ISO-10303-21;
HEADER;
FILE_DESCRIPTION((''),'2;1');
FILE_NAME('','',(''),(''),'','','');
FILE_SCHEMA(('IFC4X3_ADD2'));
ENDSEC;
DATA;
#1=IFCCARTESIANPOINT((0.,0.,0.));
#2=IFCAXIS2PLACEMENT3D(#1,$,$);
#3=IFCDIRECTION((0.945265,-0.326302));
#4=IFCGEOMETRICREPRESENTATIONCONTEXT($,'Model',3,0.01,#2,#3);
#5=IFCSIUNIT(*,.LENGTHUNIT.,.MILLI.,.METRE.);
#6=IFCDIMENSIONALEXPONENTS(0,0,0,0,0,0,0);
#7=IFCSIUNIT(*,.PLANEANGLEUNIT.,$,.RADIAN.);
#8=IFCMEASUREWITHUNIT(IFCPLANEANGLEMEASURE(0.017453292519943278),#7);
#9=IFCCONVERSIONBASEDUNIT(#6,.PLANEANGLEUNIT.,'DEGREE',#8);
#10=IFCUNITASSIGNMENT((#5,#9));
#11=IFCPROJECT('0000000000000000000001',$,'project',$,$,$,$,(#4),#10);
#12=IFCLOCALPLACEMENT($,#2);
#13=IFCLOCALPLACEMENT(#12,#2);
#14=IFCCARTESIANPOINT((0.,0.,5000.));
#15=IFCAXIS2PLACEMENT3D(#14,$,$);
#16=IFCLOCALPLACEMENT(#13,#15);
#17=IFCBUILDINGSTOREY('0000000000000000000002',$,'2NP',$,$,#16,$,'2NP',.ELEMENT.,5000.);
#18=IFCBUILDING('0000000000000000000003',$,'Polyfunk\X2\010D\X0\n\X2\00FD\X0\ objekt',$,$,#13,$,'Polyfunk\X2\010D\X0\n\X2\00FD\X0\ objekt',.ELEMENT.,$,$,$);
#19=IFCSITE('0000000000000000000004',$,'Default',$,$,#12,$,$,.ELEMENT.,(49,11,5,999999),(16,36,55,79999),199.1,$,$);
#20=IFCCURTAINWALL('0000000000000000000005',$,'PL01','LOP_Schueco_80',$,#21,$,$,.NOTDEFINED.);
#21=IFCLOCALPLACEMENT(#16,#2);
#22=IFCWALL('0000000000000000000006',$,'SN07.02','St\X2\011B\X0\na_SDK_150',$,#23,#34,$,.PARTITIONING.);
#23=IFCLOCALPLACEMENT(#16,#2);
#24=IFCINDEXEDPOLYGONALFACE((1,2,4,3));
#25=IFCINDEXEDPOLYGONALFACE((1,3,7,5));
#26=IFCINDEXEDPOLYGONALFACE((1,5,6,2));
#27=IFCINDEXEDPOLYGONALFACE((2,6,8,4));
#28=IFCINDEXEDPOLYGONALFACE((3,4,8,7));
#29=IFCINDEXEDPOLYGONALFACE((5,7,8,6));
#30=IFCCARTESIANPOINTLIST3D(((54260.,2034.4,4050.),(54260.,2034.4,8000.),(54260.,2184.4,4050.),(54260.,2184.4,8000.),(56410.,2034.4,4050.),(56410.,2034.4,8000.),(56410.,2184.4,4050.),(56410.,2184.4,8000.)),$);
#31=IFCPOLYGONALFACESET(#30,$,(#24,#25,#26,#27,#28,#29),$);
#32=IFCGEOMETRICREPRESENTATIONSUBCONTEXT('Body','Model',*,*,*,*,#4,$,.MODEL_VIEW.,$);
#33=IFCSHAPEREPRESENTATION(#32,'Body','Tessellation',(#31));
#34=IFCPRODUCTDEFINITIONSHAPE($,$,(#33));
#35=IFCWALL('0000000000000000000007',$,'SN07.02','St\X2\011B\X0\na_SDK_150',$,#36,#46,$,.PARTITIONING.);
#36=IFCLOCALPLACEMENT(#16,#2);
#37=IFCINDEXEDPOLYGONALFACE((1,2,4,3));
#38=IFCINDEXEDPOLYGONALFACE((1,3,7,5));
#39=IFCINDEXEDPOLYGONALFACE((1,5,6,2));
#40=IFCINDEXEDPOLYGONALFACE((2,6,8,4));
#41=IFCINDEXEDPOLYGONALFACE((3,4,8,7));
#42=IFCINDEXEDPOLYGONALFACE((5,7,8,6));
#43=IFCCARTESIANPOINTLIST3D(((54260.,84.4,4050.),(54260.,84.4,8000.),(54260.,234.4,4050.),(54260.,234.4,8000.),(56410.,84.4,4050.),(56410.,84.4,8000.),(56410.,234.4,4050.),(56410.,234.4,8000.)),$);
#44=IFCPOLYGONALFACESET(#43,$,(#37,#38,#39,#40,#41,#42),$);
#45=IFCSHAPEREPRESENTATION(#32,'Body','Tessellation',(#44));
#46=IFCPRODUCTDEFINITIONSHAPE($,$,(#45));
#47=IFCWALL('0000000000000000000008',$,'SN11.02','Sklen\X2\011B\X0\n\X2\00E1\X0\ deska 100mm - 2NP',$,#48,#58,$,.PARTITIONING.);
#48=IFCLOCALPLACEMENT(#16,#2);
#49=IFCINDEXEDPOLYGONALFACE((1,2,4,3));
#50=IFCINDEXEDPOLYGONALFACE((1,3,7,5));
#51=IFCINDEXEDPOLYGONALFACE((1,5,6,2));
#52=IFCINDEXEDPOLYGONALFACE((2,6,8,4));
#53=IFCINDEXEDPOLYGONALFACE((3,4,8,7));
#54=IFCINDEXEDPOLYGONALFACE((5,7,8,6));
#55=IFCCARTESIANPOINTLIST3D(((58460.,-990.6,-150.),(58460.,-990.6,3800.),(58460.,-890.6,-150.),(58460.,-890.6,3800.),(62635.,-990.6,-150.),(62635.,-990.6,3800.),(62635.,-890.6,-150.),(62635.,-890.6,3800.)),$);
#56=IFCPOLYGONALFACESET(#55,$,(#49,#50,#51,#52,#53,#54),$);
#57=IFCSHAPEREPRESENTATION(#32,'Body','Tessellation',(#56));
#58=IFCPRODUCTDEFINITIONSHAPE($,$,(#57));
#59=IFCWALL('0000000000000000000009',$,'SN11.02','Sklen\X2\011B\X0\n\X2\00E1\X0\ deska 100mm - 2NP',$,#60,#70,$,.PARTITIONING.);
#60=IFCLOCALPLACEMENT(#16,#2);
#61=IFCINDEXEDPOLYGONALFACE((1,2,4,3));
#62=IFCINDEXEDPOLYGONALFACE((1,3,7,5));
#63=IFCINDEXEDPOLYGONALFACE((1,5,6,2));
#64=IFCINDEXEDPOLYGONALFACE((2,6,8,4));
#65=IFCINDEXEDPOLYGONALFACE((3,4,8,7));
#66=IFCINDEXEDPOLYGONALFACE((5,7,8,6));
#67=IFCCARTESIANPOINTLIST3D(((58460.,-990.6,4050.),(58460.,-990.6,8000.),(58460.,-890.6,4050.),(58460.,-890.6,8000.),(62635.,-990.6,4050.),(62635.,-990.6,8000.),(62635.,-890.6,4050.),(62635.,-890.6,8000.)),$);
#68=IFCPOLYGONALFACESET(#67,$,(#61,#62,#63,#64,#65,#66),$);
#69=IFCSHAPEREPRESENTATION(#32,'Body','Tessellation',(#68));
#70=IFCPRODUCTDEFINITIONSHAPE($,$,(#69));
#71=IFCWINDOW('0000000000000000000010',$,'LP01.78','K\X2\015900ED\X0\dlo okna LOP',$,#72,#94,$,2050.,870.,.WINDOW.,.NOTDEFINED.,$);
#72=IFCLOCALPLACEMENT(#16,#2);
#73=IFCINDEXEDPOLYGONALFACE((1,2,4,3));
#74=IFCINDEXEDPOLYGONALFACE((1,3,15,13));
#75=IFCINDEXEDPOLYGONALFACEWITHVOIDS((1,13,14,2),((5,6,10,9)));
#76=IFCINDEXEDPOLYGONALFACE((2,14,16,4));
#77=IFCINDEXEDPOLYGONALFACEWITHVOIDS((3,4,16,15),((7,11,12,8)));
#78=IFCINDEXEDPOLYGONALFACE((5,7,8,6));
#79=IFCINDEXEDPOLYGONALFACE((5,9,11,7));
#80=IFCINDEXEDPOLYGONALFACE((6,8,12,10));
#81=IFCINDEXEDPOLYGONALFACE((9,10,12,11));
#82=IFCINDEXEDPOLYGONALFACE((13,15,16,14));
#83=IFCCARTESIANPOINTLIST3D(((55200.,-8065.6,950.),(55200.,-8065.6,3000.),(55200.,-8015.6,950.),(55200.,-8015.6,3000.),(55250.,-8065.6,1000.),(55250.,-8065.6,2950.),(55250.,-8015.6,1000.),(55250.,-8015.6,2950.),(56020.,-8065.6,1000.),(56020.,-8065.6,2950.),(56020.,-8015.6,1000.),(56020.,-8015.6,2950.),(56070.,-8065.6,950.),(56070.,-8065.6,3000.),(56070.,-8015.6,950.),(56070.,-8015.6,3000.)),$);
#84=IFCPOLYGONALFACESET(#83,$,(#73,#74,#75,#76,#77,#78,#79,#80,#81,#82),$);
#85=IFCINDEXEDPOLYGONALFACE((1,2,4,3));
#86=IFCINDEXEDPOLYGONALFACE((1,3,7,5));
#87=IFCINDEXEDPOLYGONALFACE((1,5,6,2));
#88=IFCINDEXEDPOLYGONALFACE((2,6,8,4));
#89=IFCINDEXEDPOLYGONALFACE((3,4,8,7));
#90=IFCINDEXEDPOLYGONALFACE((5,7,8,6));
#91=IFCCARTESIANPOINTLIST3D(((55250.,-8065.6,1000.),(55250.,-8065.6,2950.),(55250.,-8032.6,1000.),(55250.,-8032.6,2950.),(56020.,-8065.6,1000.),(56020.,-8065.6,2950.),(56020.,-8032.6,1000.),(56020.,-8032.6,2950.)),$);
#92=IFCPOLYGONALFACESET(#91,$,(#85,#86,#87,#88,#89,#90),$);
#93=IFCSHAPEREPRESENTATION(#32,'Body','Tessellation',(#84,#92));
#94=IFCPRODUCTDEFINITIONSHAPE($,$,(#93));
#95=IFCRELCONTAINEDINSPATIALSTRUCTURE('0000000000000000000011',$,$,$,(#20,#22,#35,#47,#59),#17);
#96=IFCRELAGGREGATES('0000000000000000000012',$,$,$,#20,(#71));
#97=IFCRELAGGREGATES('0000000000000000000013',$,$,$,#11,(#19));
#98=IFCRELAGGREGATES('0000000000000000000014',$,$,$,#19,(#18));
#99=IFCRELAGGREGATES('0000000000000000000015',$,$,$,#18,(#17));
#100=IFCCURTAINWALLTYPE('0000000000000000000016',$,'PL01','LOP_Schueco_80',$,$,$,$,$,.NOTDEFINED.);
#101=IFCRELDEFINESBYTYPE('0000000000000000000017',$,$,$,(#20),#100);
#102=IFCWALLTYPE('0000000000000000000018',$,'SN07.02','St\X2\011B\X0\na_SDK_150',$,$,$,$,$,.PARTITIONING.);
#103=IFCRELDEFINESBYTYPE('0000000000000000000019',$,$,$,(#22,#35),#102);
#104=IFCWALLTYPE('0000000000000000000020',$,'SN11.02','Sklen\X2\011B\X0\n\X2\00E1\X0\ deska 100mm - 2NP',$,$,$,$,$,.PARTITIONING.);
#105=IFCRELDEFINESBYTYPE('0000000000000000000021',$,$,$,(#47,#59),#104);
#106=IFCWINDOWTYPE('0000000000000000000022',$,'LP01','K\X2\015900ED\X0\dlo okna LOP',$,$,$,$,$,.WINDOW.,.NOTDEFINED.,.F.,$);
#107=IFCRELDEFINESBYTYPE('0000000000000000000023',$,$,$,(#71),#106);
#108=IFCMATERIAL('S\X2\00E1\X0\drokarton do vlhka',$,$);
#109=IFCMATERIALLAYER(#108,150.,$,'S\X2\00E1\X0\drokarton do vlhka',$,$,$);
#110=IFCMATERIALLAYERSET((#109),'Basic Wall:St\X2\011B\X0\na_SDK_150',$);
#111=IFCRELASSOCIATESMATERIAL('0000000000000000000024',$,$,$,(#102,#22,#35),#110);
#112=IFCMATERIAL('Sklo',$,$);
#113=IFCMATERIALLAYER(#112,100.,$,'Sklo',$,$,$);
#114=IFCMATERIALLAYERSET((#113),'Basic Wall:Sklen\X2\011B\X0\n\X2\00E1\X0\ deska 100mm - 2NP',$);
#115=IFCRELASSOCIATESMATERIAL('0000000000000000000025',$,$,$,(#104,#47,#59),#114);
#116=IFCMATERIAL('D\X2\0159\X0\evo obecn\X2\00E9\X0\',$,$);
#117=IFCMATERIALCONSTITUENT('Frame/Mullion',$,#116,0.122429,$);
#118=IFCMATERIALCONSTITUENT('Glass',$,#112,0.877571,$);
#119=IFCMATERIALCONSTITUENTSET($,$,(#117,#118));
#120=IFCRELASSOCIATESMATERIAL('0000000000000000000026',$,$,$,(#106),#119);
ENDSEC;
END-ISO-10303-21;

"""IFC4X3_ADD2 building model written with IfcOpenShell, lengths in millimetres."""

from ifc_helpers import new_model, entity, si_unit, converted_unit, direction, frame, frame_2d, origin, place, context, subcontext, project, spatial, polyline, rectangle, outline, extrude, clip, bounded_halfspace, source, transform, mapped, material, layer, layer_set, constituent, constituent_set, type_object, type_shapes, element, aggregate, save


model = new_model("IFC4X3_ADD2")

# Units and contexts
model_context = context("Model", 3, precision=0.01, world=origin(), true_north=direction((0.945265, -0.326302)))
body_context = subcontext(model_context, "Body", "Model", "MODEL_VIEW")
ifc_project = project(units=[si_unit("LENGTHUNIT", "METRE", prefix="MILLI"), converted_unit("PLANEANGLEUNIT", "DEGREE", entity("IfcPlaneAngleMeasure", 0.017453292519943278), si_unit("PLANEANGLEUNIT", "RADIAN"), dimensions=[0, 0, 0, 0, 0, 0, 0])], contexts=[model_context])

# Site, building, storey
site_placement = place(None, origin())
site = spatial("IfcSite", under=ifc_project, at=site_placement, Name="Default", CompositionType="ELEMENT", RefLatitude=(49, 11, 5, 999999), RefLongitude=(16, 36, 55, 79999), RefElevation=199.1)
building_placement = place(site_placement, origin())
building = spatial("IfcBuilding", under=site, at=building_placement, Name="Polyfunkčný objekt", LongName="Polyfunkčný objekt", CompositionType="ELEMENT")
storey_placement = place(building_placement, frame((0.0, 0.0, 5000.0)))
storey = spatial("IfcBuildingStorey", under=building, at=storey_placement, Name="2NP", LongName="2NP", CompositionType="ELEMENT", Elevation=5000.0)

# Curtain wall
curtain_wall_type = type_object("IfcCurtainWallType", Name="PL01", Description="LOP_Schueco_80", PredefinedType="NOTDEFINED")
curtain_wall_placement = place(storey_placement, frame((0.0, 0.0, -5000.0)))
curtain_wall = element("IfcCurtainWall", 1, at=curtain_wall_placement, inside=storey, type_object=curtain_wall_type, Name="PL01", Description="LOP_Schueco_80", PredefinedType="NOTDEFINED")
ifc_material_1 = material(Name="Sklo")

# Walls
ifc_material_2 = material(Name="Sádrokarton do vlhka")
ifc_layer_1 = layer(ifc_material_2, 150.0, Name="Sádrokarton do vlhka")
ifc_layer_set_1 = layer_set([ifc_layer_1], Name="Basic Wall:Stěna_SDK_150")
wall_type_1 = type_object("IfcWallType", Name="SN07.02", Description="Stěna_SDK_150", PredefinedType="PARTITIONING", material=ifc_layer_set_1)
wall_1_placement = place(storey_placement, frame((56410.0, 2109.4, 4050.0), z_axis=(0.0, 0.0, 1.0), x_axis=(-1.0, 0.0, 0.0)))
element("IfcWall", 2, at=wall_1_placement, inside=storey, type_object=wall_type_1, material=ifc_layer_set_1, Name="SN07.02", Description="Stěna_SDK_150", PredefinedType="PARTITIONING", context=body_context, shape_type="Clipping", body=[
    clip(clip(extrude(rectangle(XDim=2150.0, YDim=150.0, at=frame_2d((1075.0, 0.0), x_axis=(-1.0, 0.0))), origin(), (0.0, 0.0, 1.0), 3950.0), bounded_halfspace(frame((2150.0, -75.0, 0.0)), True, frame((2150.0, -75.0, 0.0)), polyline([(0.0, 0.0), (0.0, 150.0), (-2150.0, 150.0), (-2150.0, 0.0), (0.0, 0.0)]))), bounded_halfspace(frame((0.0, -75.0, 3950.0), z_axis=(0.0, 0.0, -1.0), x_axis=(-1.0, 0.0, 0.0)), True, frame((0.0, -75.0, 3950.0)), polyline([(0.0, 0.0), (2150.0, 0.0), (2150.0, 150.0), (0.0, 150.0), (0.0, 0.0)]))),
])
wall_2_placement = place(storey_placement, frame((56410.0, 159.4, 4050.0), z_axis=(0.0, 0.0, 1.0), x_axis=(-1.0, 0.0, 0.0)))
element("IfcWall", 3, at=wall_2_placement, inside=storey, type_object=wall_type_1, material=ifc_layer_set_1, Name="SN07.02", Description="Stěna_SDK_150", PredefinedType="PARTITIONING", context=body_context, shape_type="Clipping", body=[
    clip(clip(extrude(rectangle(XDim=2150.0, YDim=150.0, at=frame_2d((1075.0, 0.0), x_axis=(-1.0, 0.0))), origin(), (0.0, 0.0, 1.0), 3950.0), bounded_halfspace(frame((2150.0, -75.0, 0.0)), True, frame((2150.0, -75.0, 0.0)), polyline([(0.0, 0.0), (0.0, 150.0), (-2150.0, 150.0), (-2150.0, 0.0), (0.0, 0.0)]))), bounded_halfspace(frame((0.0, -75.0, 3950.0), z_axis=(0.0, 0.0, -1.0), x_axis=(-1.0, 0.0, 0.0)), True, frame((0.0, -75.0, 3950.0)), polyline([(0.0, 0.0), (2150.0, 0.0), (2150.0, 150.0), (0.0, 150.0), (0.0, 0.0)]))),
])
ifc_layer_2 = layer(ifc_material_1, 100.0, Name="Sklo")
ifc_layer_set_2 = layer_set([ifc_layer_2], Name="Basic Wall:Skleněná deska 100mm - 2NP")
wall_type_2 = type_object("IfcWallType", Name="SN11.02", Description="Skleněná deska 100mm - 2NP", PredefinedType="PARTITIONING", material=ifc_layer_set_2)
wall_3_placement = place(storey_placement, frame((58460.0, -940.6, -150.0)))
element("IfcWall", 4, at=wall_3_placement, inside=storey, type_object=wall_type_2, material=ifc_layer_set_2, Name="SN11.02", Description="Skleněná deska 100mm - 2NP", PredefinedType="PARTITIONING", context=body_context, shape_type="Clipping", body=[
    clip(clip(extrude(rectangle(XDim=4175.0, YDim=100.0, at=frame_2d((2087.5, 0.0), x_axis=(-1.0, 0.0))), origin(), (0.0, 0.0, 1.0), 3950.0), bounded_halfspace(frame((4175.0, -50.0, 0.0), z_axis=(0.0, 0.0, 1.0), x_axis=(-1.0, 0.0, 0.0)), True, frame((4175.0, -50.0, 0.0)), polyline([(0.0, 0.0), (0.0, 100.0), (-4075.0, 100.0), (-4175.0, 100.0), (-4175.0, 0.0), (0.0, 0.0)]))), bounded_halfspace(frame((0.0, -50.0, 3950.0), z_axis=(0.0, 0.0, -1.0), x_axis=(1.0, 0.0, 0.0)), True, frame((0.0, -50.0, 3950.0)), polyline([(0.0, 0.0), (4175.0, 0.0), (4175.0, 100.0), (100.0, 100.0), (0.0, 100.0), (0.0, 0.0)]))),
])
wall_4_placement = place(storey_placement, frame((58460.0, -940.6, 4050.0)))
element("IfcWall", 5, at=wall_4_placement, inside=storey, type_object=wall_type_2, material=ifc_layer_set_2, Name="SN11.02", Description="Skleněná deska 100mm - 2NP", PredefinedType="PARTITIONING", context=body_context, shape_type="Clipping", body=[
    clip(clip(extrude(rectangle(XDim=4175.0, YDim=100.0, at=frame_2d((2087.5, 0.0), x_axis=(-1.0, 0.0))), origin(), (0.0, 0.0, 1.0), 3950.0), bounded_halfspace(frame((4175.0, -50.0, 0.0), z_axis=(0.0, 0.0, 1.0), x_axis=(-1.0, 0.0, 0.0)), True, frame((4175.0, -50.0, 0.0)), polyline([(0.0, 0.0), (0.0, 100.0), (-4075.0, 100.0), (-4175.0, 100.0), (-4175.0, 0.0), (0.0, 0.0)]))), bounded_halfspace(frame((0.0, -50.0, 3950.0), z_axis=(0.0, 0.0, -1.0), x_axis=(1.0, 0.0, 0.0)), True, frame((0.0, -50.0, 3950.0)), polyline([(0.0, 0.0), (4175.0, 0.0), (4175.0, 100.0), (100.0, 100.0), (0.0, 100.0), (0.0, 0.0)]))),
])

# Window
ifc_material_3 = material(Name="Dřevo obecné")
ifc_constituent_1 = constituent(ifc_material_3, Name="Frame/Mullion", fraction=0.122429)
ifc_constituent_2 = constituent(ifc_material_1, Name="Glass", fraction=0.877571)
ifc_constituent_set = constituent_set(constituents=[ifc_constituent_1, ifc_constituent_2])
window_type = type_object("IfcWindowType", Name="LP01", Description="Křídlo okna LOP", ParameterTakesPrecedence=False, PartitioningType="NOTDEFINED", PredefinedType="WINDOW", material=ifc_constituent_set)
shared_shape_1 = source(origin(), body_context, "Body", "SweptSolid", [
    extrude(outline(polyline([(-1025.0, -435.0), (1025.0, -435.0), (1025.0, 435.0), (-1025.0, 435.0), (-1025.0, -435.0)]), holes=[polyline([(-975.0, -385.0), (-975.0, 385.0), (975.0, 385.0), (975.0, -385.0), (-975.0, -385.0)])]), frame((0.0, 50.0, 1025.0), z_axis=(0.0, -1.0, 0.0), x_axis=(0.0, 0.0, -1.0)), (0.0, 0.0, 1.0), 50.0),
    extrude(rectangle(XDim=770.0, YDim=33.0, at=frame_2d((0.0, 0.0), x_axis=(1.0, 0.0))), frame((0.0, 33.5, 50.0), z_axis=(0.0, 0.0, 1.0), x_axis=(-1.0, 0.0, 0.0)), (0.0, 0.0, 1.0), 1950.0),
])
type_shapes(window_type, [shared_shape_1])
window_placement = place(curtain_wall_placement, frame((55635.0, -8015.6, 5950.0), z_axis=(0.0, 0.0, 1.0), x_axis=(-1.0, 0.0, 0.0)))
window = element("IfcWindow", 6, at=window_placement, type_object=window_type, Name="LP01.78", Description="Křídlo okna LOP", OverallHeight=2050.0, OverallWidth=870.0, PartitioningType="NOTDEFINED", PredefinedType="WINDOW", context=body_context, shape_type="MappedRepresentation", body=[
    mapped(shared_shape_1, transform((0.0, 0.0, 0.0), scale=1.0)),
])
aggregate(curtain_wall, [window])

save(model, "model.ifc")
